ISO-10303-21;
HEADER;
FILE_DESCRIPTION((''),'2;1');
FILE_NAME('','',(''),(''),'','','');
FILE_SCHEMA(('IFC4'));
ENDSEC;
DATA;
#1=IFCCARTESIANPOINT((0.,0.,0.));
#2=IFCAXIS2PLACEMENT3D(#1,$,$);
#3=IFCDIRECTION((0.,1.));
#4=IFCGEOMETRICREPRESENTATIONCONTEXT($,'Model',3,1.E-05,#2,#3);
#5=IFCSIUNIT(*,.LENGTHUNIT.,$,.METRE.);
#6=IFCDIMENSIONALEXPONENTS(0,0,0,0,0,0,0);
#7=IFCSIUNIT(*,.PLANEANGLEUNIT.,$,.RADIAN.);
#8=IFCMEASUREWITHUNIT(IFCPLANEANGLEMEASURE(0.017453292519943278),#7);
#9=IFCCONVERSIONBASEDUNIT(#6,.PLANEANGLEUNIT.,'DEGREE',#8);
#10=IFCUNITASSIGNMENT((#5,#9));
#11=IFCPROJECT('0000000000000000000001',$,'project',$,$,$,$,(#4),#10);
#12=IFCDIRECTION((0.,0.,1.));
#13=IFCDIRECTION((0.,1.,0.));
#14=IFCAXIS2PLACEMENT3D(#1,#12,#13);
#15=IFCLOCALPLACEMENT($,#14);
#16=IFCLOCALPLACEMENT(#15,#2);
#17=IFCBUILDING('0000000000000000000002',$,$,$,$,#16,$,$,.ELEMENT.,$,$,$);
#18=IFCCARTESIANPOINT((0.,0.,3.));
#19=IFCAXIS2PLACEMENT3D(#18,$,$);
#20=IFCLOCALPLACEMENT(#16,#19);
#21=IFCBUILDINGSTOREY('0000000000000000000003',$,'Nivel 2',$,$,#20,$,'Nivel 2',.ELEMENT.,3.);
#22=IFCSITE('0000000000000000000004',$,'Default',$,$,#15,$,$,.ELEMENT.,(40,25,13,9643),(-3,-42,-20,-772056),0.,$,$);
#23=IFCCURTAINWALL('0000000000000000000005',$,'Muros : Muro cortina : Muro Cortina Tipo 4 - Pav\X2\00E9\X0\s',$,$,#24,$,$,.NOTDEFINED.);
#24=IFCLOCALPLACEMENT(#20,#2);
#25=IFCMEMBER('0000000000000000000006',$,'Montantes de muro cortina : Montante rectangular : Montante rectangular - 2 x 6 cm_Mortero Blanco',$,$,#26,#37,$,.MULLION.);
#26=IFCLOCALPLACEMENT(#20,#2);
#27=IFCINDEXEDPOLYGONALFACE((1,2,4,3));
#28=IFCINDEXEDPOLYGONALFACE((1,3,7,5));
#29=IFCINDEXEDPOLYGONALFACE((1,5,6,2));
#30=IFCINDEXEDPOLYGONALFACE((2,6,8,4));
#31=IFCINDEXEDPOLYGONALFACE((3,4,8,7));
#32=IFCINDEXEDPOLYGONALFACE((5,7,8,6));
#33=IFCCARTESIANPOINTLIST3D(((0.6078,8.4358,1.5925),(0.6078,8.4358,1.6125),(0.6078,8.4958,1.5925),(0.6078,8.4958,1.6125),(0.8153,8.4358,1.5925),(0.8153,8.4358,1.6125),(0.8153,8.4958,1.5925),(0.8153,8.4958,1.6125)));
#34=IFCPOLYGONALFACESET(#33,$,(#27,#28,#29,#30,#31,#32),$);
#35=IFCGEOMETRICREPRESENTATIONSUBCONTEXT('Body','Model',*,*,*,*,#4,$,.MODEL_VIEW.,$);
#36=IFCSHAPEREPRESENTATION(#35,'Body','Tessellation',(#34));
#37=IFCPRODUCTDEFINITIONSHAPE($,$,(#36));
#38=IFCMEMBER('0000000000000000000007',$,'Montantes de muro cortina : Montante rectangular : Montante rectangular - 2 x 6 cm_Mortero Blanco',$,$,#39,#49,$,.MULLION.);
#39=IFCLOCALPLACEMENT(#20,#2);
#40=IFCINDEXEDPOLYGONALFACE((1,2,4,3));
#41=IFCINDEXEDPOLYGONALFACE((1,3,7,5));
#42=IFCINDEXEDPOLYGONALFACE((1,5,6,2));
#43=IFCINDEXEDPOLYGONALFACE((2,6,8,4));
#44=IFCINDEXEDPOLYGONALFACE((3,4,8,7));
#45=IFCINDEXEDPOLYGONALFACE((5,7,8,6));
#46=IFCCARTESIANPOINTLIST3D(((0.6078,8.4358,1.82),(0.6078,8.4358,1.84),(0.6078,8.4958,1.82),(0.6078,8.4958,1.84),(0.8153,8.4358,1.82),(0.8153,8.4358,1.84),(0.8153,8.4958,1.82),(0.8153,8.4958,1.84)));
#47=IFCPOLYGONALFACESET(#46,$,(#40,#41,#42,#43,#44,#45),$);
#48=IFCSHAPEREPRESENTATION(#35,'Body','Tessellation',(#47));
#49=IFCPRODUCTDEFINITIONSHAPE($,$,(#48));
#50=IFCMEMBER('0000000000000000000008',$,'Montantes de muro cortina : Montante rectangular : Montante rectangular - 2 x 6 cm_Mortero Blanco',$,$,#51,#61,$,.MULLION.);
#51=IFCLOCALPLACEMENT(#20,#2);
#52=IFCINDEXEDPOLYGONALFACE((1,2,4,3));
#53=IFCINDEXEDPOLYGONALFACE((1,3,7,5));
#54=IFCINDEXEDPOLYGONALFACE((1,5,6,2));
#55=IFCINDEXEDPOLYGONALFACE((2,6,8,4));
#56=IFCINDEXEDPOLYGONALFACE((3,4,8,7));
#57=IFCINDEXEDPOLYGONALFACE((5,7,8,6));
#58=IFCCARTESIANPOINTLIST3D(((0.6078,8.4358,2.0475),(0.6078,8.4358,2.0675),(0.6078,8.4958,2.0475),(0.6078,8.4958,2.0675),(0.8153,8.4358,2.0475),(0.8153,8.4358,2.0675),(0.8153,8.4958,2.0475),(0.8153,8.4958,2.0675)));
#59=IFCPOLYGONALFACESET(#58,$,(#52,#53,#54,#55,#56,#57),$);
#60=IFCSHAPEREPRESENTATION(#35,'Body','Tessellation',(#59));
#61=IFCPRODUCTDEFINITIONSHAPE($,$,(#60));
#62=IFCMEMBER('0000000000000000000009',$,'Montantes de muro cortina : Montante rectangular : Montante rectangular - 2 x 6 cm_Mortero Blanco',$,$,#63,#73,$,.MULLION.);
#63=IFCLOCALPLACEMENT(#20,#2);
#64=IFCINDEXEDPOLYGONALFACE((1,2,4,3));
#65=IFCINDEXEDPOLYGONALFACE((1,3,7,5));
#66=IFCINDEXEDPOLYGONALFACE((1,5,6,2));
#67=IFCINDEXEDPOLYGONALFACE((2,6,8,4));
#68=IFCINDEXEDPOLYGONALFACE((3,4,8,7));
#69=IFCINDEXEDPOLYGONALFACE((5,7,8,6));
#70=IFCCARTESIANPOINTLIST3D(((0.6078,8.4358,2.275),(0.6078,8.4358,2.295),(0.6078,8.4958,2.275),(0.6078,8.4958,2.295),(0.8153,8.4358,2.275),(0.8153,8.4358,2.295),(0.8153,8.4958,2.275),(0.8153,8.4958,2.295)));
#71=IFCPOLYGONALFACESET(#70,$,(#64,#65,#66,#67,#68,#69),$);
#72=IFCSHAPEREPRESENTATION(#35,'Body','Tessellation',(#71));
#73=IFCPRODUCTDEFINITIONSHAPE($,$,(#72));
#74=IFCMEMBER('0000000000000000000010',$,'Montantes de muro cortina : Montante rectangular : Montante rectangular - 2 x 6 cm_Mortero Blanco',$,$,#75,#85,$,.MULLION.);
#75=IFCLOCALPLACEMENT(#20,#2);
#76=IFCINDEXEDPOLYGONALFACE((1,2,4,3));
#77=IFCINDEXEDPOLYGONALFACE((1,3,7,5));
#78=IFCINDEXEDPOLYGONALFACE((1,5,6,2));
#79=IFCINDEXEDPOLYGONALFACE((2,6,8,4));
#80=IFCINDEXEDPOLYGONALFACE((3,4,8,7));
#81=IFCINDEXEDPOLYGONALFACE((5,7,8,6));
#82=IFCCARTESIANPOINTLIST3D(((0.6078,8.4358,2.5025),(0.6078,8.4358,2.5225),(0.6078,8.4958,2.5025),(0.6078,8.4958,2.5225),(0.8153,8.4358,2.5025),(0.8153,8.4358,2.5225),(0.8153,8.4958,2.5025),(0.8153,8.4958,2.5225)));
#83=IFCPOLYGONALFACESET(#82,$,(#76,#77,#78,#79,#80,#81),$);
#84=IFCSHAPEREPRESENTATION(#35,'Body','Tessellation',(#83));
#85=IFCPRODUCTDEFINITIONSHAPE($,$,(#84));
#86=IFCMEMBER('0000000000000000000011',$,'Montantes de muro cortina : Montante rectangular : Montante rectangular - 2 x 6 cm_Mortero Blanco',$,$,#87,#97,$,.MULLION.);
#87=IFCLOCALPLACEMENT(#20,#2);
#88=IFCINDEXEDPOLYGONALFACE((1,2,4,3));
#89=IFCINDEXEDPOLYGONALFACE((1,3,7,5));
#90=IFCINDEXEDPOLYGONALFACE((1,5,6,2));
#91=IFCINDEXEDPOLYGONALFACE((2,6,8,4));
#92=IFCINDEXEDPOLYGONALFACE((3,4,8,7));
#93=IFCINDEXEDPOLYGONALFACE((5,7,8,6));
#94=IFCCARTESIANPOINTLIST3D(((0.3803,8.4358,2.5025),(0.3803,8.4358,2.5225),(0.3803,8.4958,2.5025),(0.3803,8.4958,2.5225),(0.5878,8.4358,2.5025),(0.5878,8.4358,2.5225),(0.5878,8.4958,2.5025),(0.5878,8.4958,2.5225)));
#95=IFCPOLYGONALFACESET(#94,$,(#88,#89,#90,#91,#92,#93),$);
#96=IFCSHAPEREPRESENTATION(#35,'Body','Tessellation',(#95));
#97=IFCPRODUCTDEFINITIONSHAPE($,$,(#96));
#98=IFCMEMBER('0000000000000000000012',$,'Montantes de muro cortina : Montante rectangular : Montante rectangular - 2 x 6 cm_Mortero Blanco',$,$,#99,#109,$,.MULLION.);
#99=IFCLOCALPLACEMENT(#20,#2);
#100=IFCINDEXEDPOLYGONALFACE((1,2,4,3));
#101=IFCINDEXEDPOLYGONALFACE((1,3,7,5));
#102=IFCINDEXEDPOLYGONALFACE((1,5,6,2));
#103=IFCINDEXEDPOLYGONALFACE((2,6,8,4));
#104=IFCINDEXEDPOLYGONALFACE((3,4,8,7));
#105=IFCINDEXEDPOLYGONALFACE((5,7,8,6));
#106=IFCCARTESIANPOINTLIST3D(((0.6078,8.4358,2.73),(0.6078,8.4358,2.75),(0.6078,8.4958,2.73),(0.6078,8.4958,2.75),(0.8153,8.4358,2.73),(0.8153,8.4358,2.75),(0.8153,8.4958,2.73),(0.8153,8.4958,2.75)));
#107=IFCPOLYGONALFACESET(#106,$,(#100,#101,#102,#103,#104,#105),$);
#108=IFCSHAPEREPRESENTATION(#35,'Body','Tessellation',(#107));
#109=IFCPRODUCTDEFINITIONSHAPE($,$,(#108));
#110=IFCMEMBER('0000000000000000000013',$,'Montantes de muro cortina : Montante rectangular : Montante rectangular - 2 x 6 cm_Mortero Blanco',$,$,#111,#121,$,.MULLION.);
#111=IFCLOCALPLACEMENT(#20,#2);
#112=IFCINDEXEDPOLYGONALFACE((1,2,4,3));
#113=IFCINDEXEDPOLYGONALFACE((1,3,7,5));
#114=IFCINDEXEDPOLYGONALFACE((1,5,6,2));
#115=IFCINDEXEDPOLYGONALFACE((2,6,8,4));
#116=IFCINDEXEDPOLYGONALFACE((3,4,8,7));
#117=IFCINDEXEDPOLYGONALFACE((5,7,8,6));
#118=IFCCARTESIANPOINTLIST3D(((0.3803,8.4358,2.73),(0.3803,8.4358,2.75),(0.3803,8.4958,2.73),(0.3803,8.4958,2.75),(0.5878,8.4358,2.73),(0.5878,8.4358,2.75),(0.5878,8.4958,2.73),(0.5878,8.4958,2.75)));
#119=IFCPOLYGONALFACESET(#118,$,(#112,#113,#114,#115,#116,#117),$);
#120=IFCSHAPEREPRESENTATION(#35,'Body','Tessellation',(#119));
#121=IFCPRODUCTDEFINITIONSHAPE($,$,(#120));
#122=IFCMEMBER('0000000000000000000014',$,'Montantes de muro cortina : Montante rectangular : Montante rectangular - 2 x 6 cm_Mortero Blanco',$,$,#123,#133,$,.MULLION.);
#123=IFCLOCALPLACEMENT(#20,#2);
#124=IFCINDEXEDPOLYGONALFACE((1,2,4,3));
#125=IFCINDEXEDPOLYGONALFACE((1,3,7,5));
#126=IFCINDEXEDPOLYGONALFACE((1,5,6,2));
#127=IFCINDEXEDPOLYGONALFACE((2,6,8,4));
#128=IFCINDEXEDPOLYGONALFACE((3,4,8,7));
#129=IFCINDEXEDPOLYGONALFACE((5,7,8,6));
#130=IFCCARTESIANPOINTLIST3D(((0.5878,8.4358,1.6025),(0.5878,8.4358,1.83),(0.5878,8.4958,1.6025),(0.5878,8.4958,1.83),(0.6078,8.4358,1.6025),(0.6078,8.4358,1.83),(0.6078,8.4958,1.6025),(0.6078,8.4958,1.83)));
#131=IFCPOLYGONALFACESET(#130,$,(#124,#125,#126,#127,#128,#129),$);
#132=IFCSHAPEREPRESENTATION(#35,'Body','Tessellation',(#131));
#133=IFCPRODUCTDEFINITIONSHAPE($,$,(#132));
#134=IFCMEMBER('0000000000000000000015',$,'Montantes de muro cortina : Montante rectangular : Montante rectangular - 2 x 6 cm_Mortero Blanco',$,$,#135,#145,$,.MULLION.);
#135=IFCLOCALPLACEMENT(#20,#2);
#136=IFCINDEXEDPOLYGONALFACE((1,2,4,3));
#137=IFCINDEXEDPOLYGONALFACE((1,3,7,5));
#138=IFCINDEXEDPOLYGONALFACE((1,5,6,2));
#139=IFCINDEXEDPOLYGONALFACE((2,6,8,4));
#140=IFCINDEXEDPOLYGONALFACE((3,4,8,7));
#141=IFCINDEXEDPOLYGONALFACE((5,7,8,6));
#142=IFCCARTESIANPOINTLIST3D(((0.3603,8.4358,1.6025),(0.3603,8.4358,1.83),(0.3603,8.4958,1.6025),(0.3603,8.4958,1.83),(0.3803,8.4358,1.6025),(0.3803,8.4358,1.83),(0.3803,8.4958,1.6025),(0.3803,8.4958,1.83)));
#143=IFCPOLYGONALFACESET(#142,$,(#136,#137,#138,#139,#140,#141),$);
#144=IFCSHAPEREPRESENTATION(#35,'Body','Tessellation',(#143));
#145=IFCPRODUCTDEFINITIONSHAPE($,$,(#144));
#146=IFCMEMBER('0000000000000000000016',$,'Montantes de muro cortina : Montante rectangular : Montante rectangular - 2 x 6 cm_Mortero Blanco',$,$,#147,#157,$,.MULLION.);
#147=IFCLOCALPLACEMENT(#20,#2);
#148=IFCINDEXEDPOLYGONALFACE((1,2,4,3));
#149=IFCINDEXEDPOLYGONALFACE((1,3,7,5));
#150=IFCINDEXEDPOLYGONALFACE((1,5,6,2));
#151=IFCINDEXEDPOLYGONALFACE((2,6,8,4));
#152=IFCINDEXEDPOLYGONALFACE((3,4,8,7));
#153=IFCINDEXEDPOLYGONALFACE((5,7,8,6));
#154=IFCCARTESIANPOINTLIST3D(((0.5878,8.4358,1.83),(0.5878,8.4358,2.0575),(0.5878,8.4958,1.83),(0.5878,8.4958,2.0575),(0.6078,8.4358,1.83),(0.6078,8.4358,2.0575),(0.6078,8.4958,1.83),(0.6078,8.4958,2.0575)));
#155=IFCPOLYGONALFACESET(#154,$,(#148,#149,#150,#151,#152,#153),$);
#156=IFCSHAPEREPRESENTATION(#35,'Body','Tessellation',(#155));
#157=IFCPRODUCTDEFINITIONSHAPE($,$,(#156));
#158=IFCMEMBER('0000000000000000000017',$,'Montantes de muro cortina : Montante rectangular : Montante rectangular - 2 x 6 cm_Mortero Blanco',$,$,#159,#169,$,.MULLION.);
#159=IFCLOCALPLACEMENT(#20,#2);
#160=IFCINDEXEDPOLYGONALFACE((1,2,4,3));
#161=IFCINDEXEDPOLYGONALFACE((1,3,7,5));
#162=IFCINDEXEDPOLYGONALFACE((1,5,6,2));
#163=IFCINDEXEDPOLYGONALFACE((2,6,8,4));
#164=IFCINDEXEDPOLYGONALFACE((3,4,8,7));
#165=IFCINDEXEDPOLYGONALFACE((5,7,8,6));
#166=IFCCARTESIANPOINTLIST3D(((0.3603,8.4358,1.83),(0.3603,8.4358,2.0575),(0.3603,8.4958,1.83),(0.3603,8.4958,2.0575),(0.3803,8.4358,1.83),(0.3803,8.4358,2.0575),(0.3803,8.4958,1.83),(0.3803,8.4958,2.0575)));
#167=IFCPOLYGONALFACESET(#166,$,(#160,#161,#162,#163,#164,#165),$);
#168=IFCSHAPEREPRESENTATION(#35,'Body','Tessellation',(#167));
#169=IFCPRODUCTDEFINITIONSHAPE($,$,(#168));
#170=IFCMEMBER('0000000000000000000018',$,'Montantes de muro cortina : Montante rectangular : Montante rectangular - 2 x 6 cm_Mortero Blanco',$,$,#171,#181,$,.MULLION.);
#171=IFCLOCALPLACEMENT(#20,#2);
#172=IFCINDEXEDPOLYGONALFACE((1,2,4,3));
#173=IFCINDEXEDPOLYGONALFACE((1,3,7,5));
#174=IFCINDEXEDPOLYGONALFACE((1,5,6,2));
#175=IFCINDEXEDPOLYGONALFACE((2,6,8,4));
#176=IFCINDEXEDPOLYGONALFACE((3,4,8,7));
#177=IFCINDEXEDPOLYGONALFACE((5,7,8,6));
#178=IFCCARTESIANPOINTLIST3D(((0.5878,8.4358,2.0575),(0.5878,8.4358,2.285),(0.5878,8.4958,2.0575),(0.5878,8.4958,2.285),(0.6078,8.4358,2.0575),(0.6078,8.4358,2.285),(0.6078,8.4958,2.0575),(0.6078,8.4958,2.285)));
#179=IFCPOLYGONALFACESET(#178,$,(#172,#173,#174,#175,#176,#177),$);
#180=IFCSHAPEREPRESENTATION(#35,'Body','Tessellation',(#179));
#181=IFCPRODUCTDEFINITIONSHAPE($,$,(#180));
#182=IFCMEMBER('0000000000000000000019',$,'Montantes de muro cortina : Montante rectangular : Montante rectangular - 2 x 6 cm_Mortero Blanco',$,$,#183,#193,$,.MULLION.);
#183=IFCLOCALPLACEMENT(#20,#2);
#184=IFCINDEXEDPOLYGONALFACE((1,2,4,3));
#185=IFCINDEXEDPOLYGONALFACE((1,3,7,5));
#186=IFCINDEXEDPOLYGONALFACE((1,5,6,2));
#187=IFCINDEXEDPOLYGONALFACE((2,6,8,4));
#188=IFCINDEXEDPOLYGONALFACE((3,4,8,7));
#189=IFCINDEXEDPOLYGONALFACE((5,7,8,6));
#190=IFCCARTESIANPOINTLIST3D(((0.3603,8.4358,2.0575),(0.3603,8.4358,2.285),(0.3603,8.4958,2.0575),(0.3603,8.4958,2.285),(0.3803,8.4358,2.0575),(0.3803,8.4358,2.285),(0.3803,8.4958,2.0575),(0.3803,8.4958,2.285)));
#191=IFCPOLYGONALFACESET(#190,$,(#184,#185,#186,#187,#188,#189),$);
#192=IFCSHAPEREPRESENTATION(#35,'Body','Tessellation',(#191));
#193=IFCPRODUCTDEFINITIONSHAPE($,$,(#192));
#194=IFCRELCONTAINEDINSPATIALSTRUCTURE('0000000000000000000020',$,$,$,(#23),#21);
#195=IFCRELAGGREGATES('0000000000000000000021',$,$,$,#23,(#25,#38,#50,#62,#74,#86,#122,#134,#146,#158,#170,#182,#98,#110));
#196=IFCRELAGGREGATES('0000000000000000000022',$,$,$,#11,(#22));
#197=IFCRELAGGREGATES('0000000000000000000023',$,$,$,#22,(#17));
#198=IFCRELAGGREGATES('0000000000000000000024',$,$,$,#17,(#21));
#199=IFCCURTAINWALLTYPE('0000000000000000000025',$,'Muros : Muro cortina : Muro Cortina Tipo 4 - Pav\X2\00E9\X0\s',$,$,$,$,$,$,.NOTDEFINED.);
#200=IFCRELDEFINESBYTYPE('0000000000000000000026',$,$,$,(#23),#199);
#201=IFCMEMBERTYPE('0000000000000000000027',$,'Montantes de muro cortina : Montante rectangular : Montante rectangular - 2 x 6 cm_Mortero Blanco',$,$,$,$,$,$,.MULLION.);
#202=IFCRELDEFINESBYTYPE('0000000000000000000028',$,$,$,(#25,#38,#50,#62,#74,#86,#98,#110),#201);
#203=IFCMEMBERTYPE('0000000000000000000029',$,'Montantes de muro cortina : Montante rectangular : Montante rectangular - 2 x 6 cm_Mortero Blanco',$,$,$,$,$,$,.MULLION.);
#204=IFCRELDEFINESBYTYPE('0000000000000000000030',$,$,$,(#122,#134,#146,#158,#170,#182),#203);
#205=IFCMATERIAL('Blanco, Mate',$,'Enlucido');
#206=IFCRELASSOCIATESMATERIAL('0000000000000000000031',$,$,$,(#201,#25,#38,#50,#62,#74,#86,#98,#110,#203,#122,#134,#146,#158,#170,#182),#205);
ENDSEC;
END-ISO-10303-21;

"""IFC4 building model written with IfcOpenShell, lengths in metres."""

from ifc_helpers import new_model, entity, si_unit, converted_unit, direction, frame, origin, place, context, subcontext, project, spatial, indexed_curve, outline, extrude, source, transform, mapped, material, type_object, type_shapes, element, aggregate, save


model = new_model("IFC4")

# Units and contexts
model_context = context("Model", 3, precision=1e-05, world=origin(), true_north=direction((0.0, 1.0)))
body_context = subcontext(model_context, "Body", "Model", "MODEL_VIEW")
ifc_project = project(units=[si_unit("LENGTHUNIT", "METRE"), converted_unit("PLANEANGLEUNIT", "DEGREE", entity("IfcPlaneAngleMeasure", 0.017453292519943278), si_unit("PLANEANGLEUNIT", "RADIAN"), dimensions=[0, 0, 0, 0, 0, 0, 0])], contexts=[model_context])

# Site, building, storey
site_placement = place(None, frame((0.0, 0.0, 0.0), z_axis=(0.0, 0.0, 1.0), x_axis=(0.0, 1.0, 0.0)))
site = spatial("IfcSite", under=ifc_project, at=site_placement, Name="Default", CompositionType="ELEMENT", RefLatitude=(40, 25, 13, 9643), RefLongitude=(-3, -42, -20, -772056), RefElevation=0.0)
building_placement = place(site_placement, origin())
building = spatial("IfcBuilding", under=site, at=building_placement, CompositionType="ELEMENT")
storey_placement = place(building_placement, frame((0.0, 0.0, 3.0)))
storey = spatial("IfcBuildingStorey", under=building, at=storey_placement, Name="Nivel 2", LongName="Nivel 2", CompositionType="ELEMENT", Elevation=3.0)

# Curtain wall, members
curtain_wall_type = type_object("IfcCurtainWallType", Name="Muros : Muro cortina : Muro Cortina Tipo 4 - Pavés", PredefinedType="NOTDEFINED")
curtain_wall_placement = place(storey_placement, frame((0.0, 0.0, -3.0)))
curtain_wall = element("IfcCurtainWall", 1, at=curtain_wall_placement, inside=storey, type_object=curtain_wall_type, Name="Muros : Muro cortina : Muro Cortina Tipo 4 - Pavés", PredefinedType="NOTDEFINED")
ifc_material_1 = material(Name="Blanco, Mate", Category="Enlucido")
member_type_1 = type_object("IfcMemberType", Name="Montantes de muro cortina : Montante rectangular : Montante rectangular - 2 x 6 cm_Mortero Blanco", PredefinedType="MULLION", material=ifc_material_1)
shared_shape_1 = source(origin(), body_context, "Body", "SweptSolid", [
    extrude(outline(indexed_curve([(-0.01, -0.03), (0.01, -0.03), (0.01, 0.03), (-0.01, 0.03), (-0.01, -0.03)], self_intersect=False)), frame((0.0, 0.0, -0.2075), z_axis=(0.0, 0.0, 1.0), x_axis=(-1.0, 0.0, 0.0)), (0.0, 0.0, 1.0), 0.2075),
])
type_shapes(member_type_1, [shared_shape_1])
member_1_placement = place(curtain_wall_placement, frame((0.6078, 8.4658, 4.6025), z_axis=(-1.0, 0.0, 0.0), x_axis=(0.0, 0.0, 1.0)))
member_1 = element("IfcMember", 2, at=member_1_placement, type_object=member_type_1, material=ifc_material_1, Name="Montantes de muro cortina : Montante rectangular : Montante rectangular - 2 x 6 cm_Mortero Blanco", PredefinedType="MULLION", context=body_context, shape_type="MappedRepresentation", body=[
    mapped(shared_shape_1, transform((0.0, 0.0, 0.0), scale=1.0)),
])
member_2_placement = place(curtain_wall_placement, frame((0.6078, 8.4658, 4.83), z_axis=(-1.0, 0.0, 0.0), x_axis=(0.0, 0.0, 1.0)))
member_2 = element("IfcMember", 3, at=member_2_placement, type_object=member_type_1, material=ifc_material_1, Name="Montantes de muro cortina : Montante rectangular : Montante rectangular - 2 x 6 cm_Mortero Blanco", PredefinedType="MULLION", context=body_context, shape_type="MappedRepresentation", body=[
    mapped(shared_shape_1, transform((0.0, 0.0, 0.0), scale=1.0)),
])
member_3_placement = place(curtain_wall_placement, frame((0.6078, 8.4658, 5.0575), z_axis=(-1.0, 0.0, 0.0), x_axis=(0.0, 0.0, 1.0)))
member_3 = element("IfcMember", 4, at=member_3_placement, type_object=member_type_1, material=ifc_material_1, Name="Montantes de muro cortina : Montante rectangular : Montante rectangular - 2 x 6 cm_Mortero Blanco", PredefinedType="MULLION", context=body_context, shape_type="MappedRepresentation", body=[
    mapped(shared_shape_1, transform((0.0, 0.0, 0.0), scale=1.0)),
])
member_4_placement = place(curtain_wall_placement, frame((0.6078, 8.4658, 5.285), z_axis=(-1.0, 0.0, 0.0), x_axis=(0.0, 0.0, 1.0)))
member_4 = element("IfcMember", 5, at=member_4_placement, type_object=member_type_1, material=ifc_material_1, Name="Montantes de muro cortina : Montante rectangular : Montante rectangular - 2 x 6 cm_Mortero Blanco", PredefinedType="MULLION", context=body_context, shape_type="MappedRepresentation", body=[
    mapped(shared_shape_1, transform((0.0, 0.0, 0.0), scale=1.0)),
])
member_5_placement = place(curtain_wall_placement, frame((0.6078, 8.4658, 5.5125), z_axis=(-1.0, 0.0, 0.0), x_axis=(0.0, 0.0, 1.0)))
member_5 = element("IfcMember", 6, at=member_5_placement, type_object=member_type_1, material=ifc_material_1, Name="Montantes de muro cortina : Montante rectangular : Montante rectangular - 2 x 6 cm_Mortero Blanco", PredefinedType="MULLION", context=body_context, shape_type="MappedRepresentation", body=[
    mapped(shared_shape_1, transform((0.0, 0.0, 0.0), scale=1.0)),
])
member_6_placement = place(curtain_wall_placement, frame((0.3803, 8.4658, 5.5125), z_axis=(-1.0, 0.0, 0.0), x_axis=(0.0, 0.0, 1.0)))
member_6 = element("IfcMember", 7, at=member_6_placement, type_object=member_type_1, material=ifc_material_1, Name="Montantes de muro cortina : Montante rectangular : Montante rectangular - 2 x 6 cm_Mortero Blanco", PredefinedType="MULLION", context=body_context, shape_type="MappedRepresentation", body=[
    mapped(shared_shape_1, transform((0.0, 0.0, 0.0), scale=1.0)),
])
member_7_placement = place(curtain_wall_placement, frame((0.6078, 8.4658, 5.74), z_axis=(-1.0, 0.0, 0.0), x_axis=(0.0, 0.0, 1.0)))
member_7 = element("IfcMember", 8, at=member_7_placement, type_object=member_type_1, material=ifc_material_1, Name="Montantes de muro cortina : Montante rectangular : Montante rectangular - 2 x 6 cm_Mortero Blanco", PredefinedType="MULLION", context=body_context, shape_type="MappedRepresentation", body=[
    mapped(shared_shape_1, transform((0.0, 0.0, 0.0), scale=1.0)),
])
member_8_placement = place(curtain_wall_placement, frame((0.3803, 8.4658, 5.74), z_axis=(-1.0, 0.0, 0.0), x_axis=(0.0, 0.0, 1.0)))
member_8 = element("IfcMember", 9, at=member_8_placement, type_object=member_type_1, material=ifc_material_1, Name="Montantes de muro cortina : Montante rectangular : Montante rectangular - 2 x 6 cm_Mortero Blanco", PredefinedType="MULLION", context=body_context, shape_type="MappedRepresentation", body=[
    mapped(shared_shape_1, transform((0.0, 0.0, 0.0), scale=1.0)),
])
member_type_2 = type_object("IfcMemberType", Name="Montantes de muro cortina : Montante rectangular : Montante rectangular - 2 x 6 cm_Mortero Blanco", PredefinedType="MULLION", material=ifc_material_1)
shared_shape_2 = source(origin(), body_context, "Body", "SweptSolid", [
    extrude(outline(indexed_curve([(-0.01, -0.03), (0.01, -0.03), (0.01, 0.03), (-0.01, 0.03), (-0.01, -0.03)], self_intersect=False)), frame((0.0, 0.0, -0.2275), z_axis=(0.0, 0.0, 1.0), x_axis=(-1.0, 0.0, 0.0)), (0.0, 0.0, 1.0), 0.2275),
])
type_shapes(member_type_2, [shared_shape_2])
member_9_placement = place(curtain_wall_placement, frame((0.5978, 8.4658, 4.6025), z_axis=(0.0, 0.0, -1.0), x_axis=(-1.0, 0.0, 0.0)))
member_9 = element("IfcMember", 10, at=member_9_placement, type_object=member_type_2, material=ifc_material_1, Name="Montantes de muro cortina : Montante rectangular : Montante rectangular - 2 x 6 cm_Mortero Blanco", PredefinedType="MULLION", context=body_context, shape_type="MappedRepresentation", body=[
    mapped(shared_shape_2, transform((0.0, 0.0, 0.0), scale=1.0)),
])
member_10_placement = place(curtain_wall_placement, frame((0.3703, 8.4658, 4.6025), z_axis=(0.0, 0.0, -1.0), x_axis=(-1.0, 0.0, 0.0)))
member_10 = element("IfcMember", 11, at=member_10_placement, type_object=member_type_2, material=ifc_material_1, Name="Montantes de muro cortina : Montante rectangular : Montante rectangular - 2 x 6 cm_Mortero Blanco", PredefinedType="MULLION", context=body_context, shape_type="MappedRepresentation", body=[
    mapped(shared_shape_2, transform((0.0, 0.0, 0.0), scale=1.0)),
])
member_11_placement = place(curtain_wall_placement, frame((0.5978, 8.4658, 4.83), z_axis=(0.0, 0.0, -1.0), x_axis=(-1.0, 0.0, 0.0)))
member_11 = element("IfcMember", 12, at=member_11_placement, type_object=member_type_2, material=ifc_material_1, Name="Montantes de muro cortina : Montante rectangular : Montante rectangular - 2 x 6 cm_Mortero Blanco", PredefinedType="MULLION", context=body_context, shape_type="MappedRepresentation", body=[
    mapped(shared_shape_2, transform((0.0, 0.0, 0.0), scale=1.0)),
])
member_12_placement = place(curtain_wall_placement, frame((0.3703, 8.4658, 4.83), z_axis=(0.0, 0.0, -1.0), x_axis=(-1.0, 0.0, 0.0)))
member_12 = element("IfcMember", 13, at=member_12_placement, type_object=member_type_2, material=ifc_material_1, Name="Montantes de muro cortina : Montante rectangular : Montante rectangular - 2 x 6 cm_Mortero Blanco", PredefinedType="MULLION", context=body_context, shape_type="MappedRepresentation", body=[
    mapped(shared_shape_2, transform((0.0, 0.0, 0.0), scale=1.0)),
])
member_13_placement = place(curtain_wall_placement, frame((0.5978, 8.4658, 5.0575), z_axis=(0.0, 0.0, -1.0), x_axis=(-1.0, 0.0, 0.0)))
member_13 = element("IfcMember", 14, at=member_13_placement, type_object=member_type_2, material=ifc_material_1, Name="Montantes de muro cortina : Montante rectangular : Montante rectangular - 2 x 6 cm_Mortero Blanco", PredefinedType="MULLION", context=body_context, shape_type="MappedRepresentation", body=[
    mapped(shared_shape_2, transform((0.0, 0.0, 0.0), scale=1.0)),
])
member_14_placement = place(curtain_wall_placement, frame((0.3703, 8.4658, 5.0575), z_axis=(0.0, 0.0, -1.0), x_axis=(-1.0, 0.0, 0.0)))
member_14 = element("IfcMember", 15, at=member_14_placement, type_object=member_type_2, material=ifc_material_1, Name="Montantes de muro cortina : Montante rectangular : Montante rectangular - 2 x 6 cm_Mortero Blanco", PredefinedType="MULLION", context=body_context, shape_type="MappedRepresentation", body=[
    mapped(shared_shape_2, transform((0.0, 0.0, 0.0), scale=1.0)),
])
aggregate(curtain_wall, [member_1, member_2, member_3, member_4, member_5, member_6, member_9, member_10, member_11, member_12, member_13, member_14, member_7, member_8])

save(model, "model.ifc")
